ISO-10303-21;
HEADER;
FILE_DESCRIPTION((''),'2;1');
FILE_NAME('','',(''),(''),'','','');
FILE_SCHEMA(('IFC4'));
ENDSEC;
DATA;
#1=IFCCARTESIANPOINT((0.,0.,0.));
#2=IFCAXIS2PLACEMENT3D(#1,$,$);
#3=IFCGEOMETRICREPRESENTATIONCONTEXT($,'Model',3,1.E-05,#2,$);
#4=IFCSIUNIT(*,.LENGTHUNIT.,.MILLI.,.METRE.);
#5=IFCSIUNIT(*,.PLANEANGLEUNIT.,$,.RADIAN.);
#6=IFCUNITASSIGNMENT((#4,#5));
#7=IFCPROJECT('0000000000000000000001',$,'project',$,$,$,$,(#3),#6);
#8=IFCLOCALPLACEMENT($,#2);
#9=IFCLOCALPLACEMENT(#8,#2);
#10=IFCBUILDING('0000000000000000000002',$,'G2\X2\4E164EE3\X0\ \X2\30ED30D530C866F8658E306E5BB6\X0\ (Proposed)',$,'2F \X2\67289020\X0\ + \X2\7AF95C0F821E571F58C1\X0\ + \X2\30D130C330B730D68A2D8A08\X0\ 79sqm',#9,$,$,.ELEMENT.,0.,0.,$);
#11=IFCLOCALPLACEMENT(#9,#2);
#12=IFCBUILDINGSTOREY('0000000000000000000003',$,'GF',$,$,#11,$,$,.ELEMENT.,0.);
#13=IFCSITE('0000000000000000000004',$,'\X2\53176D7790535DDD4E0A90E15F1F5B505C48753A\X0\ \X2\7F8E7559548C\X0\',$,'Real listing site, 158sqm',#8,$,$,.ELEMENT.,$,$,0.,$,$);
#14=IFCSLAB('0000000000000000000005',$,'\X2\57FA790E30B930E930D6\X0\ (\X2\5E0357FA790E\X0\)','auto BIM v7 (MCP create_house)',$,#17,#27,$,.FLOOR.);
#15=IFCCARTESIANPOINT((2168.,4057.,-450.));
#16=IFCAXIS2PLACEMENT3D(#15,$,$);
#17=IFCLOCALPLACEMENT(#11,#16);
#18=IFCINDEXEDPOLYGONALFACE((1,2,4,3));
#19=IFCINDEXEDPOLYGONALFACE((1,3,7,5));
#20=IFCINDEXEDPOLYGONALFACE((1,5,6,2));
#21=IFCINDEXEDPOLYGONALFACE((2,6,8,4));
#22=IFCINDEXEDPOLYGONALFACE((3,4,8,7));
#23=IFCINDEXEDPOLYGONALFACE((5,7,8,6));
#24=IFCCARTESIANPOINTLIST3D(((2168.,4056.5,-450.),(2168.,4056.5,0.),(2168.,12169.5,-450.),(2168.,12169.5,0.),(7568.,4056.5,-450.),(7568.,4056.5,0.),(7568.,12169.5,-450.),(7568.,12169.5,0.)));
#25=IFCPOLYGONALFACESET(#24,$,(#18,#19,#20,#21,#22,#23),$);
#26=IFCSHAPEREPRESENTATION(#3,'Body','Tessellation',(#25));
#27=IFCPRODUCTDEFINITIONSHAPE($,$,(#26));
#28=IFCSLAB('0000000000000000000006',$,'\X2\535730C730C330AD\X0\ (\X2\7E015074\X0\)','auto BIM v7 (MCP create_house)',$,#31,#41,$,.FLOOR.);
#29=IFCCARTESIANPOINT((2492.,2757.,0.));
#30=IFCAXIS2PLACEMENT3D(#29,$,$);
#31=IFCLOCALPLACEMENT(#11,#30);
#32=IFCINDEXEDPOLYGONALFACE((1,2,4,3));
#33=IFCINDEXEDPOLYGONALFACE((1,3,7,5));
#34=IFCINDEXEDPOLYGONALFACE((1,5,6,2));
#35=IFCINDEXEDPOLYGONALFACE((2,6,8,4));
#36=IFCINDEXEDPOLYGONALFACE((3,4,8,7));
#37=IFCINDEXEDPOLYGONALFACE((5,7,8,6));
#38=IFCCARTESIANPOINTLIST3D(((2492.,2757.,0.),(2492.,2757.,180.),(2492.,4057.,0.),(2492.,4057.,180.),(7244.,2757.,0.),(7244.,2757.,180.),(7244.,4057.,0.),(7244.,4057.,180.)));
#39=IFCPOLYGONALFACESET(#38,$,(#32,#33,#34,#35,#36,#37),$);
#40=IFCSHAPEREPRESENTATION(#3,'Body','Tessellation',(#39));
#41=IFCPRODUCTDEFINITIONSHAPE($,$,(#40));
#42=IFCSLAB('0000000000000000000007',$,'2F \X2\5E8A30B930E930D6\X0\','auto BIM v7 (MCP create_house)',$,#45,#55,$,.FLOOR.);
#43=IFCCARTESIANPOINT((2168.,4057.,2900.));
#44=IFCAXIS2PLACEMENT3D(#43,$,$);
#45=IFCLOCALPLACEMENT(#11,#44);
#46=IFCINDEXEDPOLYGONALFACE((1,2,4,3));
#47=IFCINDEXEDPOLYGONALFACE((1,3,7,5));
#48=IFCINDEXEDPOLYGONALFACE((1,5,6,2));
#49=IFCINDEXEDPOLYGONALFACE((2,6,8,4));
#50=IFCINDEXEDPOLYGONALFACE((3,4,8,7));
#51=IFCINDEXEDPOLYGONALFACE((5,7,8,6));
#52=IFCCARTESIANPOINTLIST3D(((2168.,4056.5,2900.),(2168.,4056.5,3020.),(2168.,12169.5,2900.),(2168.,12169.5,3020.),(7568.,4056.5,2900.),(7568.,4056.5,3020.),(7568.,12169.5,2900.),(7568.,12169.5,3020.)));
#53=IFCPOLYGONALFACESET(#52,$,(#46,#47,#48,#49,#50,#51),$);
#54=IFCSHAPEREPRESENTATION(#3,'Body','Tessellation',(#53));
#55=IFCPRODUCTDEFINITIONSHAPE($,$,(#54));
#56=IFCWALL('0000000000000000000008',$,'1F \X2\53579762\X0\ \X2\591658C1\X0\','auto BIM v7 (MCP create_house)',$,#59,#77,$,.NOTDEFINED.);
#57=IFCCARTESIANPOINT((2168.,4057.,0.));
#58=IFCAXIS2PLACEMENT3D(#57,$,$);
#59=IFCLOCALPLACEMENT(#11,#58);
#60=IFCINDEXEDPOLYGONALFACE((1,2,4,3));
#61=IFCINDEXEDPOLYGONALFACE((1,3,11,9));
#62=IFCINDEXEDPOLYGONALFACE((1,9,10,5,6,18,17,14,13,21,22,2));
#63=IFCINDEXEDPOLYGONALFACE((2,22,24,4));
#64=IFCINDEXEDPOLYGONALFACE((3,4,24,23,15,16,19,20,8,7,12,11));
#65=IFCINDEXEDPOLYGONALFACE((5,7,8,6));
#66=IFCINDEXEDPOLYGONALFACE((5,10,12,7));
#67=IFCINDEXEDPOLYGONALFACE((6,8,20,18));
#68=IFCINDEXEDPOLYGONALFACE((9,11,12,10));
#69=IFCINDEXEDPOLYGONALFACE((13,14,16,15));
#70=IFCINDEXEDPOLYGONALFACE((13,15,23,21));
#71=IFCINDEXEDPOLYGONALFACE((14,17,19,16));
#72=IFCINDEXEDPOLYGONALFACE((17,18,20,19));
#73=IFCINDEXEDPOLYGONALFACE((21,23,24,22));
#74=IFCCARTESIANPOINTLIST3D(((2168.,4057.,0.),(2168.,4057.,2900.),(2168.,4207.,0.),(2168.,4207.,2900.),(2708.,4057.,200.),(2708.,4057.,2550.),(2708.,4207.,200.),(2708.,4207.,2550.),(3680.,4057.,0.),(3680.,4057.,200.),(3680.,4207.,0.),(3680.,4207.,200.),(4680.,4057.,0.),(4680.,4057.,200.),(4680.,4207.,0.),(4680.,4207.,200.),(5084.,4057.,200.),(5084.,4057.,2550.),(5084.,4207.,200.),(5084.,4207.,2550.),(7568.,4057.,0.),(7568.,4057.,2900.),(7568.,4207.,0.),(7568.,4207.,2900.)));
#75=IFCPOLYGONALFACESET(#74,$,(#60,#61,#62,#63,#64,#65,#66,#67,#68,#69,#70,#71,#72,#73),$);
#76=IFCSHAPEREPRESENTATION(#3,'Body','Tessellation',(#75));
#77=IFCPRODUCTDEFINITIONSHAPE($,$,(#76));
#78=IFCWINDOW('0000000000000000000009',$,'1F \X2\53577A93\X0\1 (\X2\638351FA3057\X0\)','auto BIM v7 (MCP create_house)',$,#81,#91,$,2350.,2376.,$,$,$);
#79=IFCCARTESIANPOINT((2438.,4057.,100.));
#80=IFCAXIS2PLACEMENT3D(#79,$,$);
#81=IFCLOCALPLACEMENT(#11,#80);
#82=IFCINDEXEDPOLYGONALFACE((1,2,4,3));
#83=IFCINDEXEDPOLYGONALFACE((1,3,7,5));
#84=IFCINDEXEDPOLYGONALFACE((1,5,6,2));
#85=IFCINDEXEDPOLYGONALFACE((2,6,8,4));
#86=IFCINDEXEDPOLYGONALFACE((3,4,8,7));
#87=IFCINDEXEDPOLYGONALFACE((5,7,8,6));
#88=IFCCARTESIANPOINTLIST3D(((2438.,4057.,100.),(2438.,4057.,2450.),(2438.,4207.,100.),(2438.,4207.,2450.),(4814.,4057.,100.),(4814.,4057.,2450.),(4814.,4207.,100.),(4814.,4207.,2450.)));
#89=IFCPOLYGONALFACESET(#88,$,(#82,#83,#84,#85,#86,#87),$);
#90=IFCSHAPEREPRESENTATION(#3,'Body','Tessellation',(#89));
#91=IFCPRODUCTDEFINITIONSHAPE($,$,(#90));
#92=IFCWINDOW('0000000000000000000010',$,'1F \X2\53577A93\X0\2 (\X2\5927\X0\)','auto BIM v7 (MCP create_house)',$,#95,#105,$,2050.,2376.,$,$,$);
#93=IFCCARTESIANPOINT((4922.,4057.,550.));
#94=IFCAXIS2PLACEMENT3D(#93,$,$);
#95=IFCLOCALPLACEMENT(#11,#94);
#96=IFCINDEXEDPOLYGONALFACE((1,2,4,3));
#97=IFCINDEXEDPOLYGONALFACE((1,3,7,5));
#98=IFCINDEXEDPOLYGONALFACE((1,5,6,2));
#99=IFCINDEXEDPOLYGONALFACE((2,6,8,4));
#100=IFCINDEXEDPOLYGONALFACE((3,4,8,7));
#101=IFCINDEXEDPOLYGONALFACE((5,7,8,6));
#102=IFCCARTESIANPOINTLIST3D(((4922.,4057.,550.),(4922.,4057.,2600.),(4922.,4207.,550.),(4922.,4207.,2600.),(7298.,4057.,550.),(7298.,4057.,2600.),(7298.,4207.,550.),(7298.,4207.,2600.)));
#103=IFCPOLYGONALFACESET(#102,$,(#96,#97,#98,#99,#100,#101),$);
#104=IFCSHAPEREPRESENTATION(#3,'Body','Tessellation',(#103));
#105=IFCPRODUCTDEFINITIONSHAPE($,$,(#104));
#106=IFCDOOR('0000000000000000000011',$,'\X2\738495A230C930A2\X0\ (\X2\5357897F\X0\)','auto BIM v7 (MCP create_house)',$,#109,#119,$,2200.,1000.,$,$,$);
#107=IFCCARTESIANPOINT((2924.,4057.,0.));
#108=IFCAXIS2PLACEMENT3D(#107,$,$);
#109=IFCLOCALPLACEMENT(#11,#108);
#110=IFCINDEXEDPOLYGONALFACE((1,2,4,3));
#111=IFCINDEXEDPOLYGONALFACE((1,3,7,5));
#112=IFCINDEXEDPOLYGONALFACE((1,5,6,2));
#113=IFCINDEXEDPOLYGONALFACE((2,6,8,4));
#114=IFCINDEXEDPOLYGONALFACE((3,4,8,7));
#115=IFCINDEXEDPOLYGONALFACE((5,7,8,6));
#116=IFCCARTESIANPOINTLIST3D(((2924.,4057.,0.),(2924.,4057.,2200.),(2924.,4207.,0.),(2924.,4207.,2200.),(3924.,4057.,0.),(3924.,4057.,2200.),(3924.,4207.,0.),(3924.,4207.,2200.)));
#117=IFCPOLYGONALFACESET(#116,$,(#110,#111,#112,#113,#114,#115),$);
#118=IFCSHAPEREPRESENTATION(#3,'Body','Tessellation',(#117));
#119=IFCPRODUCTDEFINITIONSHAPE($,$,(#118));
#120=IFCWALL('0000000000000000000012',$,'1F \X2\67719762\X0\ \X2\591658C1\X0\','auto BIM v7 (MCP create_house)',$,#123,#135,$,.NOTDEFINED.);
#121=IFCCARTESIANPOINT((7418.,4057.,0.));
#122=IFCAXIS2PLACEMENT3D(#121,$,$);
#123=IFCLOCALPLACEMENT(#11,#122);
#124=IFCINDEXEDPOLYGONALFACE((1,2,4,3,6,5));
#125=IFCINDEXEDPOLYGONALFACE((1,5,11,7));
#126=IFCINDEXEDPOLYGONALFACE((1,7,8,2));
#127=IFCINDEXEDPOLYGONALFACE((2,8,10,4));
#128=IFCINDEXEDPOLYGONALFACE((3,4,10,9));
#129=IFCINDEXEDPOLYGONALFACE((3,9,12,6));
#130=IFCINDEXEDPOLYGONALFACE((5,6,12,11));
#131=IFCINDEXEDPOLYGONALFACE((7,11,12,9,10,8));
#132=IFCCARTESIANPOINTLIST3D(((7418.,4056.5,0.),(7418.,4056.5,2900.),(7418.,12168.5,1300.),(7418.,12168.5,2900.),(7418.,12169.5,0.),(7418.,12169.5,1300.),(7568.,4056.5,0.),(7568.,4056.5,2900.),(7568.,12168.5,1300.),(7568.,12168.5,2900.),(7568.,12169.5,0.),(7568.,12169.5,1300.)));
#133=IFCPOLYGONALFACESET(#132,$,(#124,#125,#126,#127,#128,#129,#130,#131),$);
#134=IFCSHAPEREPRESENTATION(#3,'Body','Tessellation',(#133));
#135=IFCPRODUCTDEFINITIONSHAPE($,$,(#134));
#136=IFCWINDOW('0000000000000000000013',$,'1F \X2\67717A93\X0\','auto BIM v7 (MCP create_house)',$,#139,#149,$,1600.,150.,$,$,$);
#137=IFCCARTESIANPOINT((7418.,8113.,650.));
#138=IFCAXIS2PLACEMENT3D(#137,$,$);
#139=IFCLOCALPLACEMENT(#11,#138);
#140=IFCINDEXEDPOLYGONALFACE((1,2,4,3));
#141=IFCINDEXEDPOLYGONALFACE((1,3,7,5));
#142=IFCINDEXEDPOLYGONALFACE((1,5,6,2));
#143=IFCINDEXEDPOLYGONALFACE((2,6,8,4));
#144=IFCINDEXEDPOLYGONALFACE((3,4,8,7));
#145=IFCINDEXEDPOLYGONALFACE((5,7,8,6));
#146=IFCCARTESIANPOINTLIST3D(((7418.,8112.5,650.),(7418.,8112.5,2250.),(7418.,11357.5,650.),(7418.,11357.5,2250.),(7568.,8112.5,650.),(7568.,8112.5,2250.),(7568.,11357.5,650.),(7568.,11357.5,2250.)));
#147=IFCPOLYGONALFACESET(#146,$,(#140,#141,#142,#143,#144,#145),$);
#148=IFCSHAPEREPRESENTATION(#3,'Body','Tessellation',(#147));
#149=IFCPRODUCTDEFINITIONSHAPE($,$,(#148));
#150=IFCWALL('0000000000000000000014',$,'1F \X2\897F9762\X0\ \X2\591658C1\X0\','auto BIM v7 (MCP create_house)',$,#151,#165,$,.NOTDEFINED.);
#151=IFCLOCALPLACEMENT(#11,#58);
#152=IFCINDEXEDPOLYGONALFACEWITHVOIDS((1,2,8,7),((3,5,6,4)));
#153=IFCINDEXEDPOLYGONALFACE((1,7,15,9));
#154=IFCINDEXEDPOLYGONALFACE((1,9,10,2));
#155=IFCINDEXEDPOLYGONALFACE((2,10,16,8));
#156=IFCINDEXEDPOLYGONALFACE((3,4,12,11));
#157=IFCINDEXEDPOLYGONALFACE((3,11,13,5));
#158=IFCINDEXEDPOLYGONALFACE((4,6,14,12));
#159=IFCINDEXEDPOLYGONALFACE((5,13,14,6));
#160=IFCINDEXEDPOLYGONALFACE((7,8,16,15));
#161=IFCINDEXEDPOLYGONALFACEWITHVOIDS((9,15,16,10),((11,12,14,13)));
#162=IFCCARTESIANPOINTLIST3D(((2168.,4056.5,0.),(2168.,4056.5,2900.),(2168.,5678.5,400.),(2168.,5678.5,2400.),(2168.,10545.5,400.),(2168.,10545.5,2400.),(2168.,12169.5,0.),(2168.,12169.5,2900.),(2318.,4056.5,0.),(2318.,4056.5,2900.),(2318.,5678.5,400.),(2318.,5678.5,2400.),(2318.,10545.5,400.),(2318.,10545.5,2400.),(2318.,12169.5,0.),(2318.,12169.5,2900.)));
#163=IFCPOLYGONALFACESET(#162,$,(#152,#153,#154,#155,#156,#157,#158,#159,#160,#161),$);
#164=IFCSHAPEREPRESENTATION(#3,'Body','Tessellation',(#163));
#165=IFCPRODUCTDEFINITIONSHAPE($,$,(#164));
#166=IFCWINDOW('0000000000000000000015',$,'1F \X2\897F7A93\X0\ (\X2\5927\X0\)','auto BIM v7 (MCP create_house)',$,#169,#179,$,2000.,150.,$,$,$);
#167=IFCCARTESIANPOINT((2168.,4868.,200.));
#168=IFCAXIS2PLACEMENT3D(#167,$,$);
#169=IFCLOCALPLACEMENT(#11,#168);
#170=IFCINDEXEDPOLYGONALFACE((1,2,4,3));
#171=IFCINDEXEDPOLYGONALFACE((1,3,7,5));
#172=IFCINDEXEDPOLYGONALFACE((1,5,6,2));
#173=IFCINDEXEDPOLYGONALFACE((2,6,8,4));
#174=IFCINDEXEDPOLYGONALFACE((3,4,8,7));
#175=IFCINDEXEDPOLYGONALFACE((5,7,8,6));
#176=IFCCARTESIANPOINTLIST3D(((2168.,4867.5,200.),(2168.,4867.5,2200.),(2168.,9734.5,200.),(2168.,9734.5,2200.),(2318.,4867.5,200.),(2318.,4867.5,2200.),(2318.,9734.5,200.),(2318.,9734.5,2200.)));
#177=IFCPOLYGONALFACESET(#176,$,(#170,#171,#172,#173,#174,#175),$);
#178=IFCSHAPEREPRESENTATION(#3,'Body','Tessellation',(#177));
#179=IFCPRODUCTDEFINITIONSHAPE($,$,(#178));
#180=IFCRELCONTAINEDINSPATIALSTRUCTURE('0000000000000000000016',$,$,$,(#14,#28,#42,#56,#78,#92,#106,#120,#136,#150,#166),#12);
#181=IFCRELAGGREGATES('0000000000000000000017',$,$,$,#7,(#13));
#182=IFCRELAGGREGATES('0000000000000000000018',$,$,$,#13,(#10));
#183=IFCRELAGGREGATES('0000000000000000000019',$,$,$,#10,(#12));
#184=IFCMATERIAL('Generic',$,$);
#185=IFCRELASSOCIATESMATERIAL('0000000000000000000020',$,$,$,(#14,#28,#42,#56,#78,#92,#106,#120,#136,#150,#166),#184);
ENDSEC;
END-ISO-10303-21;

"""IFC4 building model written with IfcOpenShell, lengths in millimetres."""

from ifc_helpers import new_model, si_unit, frame, frame_2d, origin, place, context, project, spatial, rectangle, extrude, material, element, fill, save


model = new_model("IFC4")

# Units and contexts
model_context = context("Model", 3, precision=1e-05, world=origin())
ifc_project = project(units=[si_unit("LENGTHUNIT", "METRE", prefix="MILLI"), si_unit("PLANEANGLEUNIT", "RADIAN")], contexts=[model_context])

# Site, building, storey
site_placement = place(None, origin())
site = spatial("IfcSite", under=ifc_project, at=site_placement, Name="北海道川上郡弟子屈町 美留和", ObjectType="Real listing site, 158sqm", CompositionType="ELEMENT", RefElevation=0.0)
building_placement = place(site_placement, origin())
building = spatial("IfcBuilding", under=site, at=building_placement, Name="G2世代 ロフト書斎の家 (Proposed)", ObjectType="2F 木造 + 竹小舞土壁 + パッシブ設計 79sqm", CompositionType="ELEMENT", ElevationOfRefHeight=0.0, ElevationOfTerrain=0.0)
storey_placement = place(building_placement, origin())
storey = spatial("IfcBuildingStorey", under=building, at=storey_placement, Name="GF", CompositionType="ELEMENT", Elevation=0.0)

# Slabs
ifc_material = material(Name="Generic")
slab_1_placement = place(storey_placement, frame((2168.0, 4057.0, -450.0)))
element("IfcSlab", 1, at=slab_1_placement, inside=storey, material=ifc_material, Name="基礎スラブ (布基礎)", Description="auto BIM v7 (MCP create_house)", PredefinedType="FLOOR", context=model_context, shape_type="SweptSolid", body=[
    extrude(rectangle(XDim=5400.0, YDim=8113.0, at=frame_2d((2700.0, 4056.0))), frame((2168.0, 4057.0, -450.0)), (0.0, 0.0, 1.0), 450.0),
])
slab_2_placement = place(storey_placement, frame((2492.0, 2757.0, 0.0)))
element("IfcSlab", 2, at=slab_2_placement, inside=storey, material=ifc_material, Name="南デッキ (縁側)", Description="auto BIM v7 (MCP create_house)", PredefinedType="FLOOR", context=model_context, shape_type="SweptSolid", body=[
    extrude(rectangle(XDim=4752.0, YDim=1300.0, at=frame_2d((2376.0, 650.0))), frame((2492.0, 2757.0, 0.0)), (0.0, 0.0, 1.0), 180.0),
])
slab_3_placement = place(storey_placement, frame((2168.0, 4057.0, 2900.0)))
element("IfcSlab", 3, at=slab_3_placement, inside=storey, material=ifc_material, Name="2F 床スラブ", Description="auto BIM v7 (MCP create_house)", PredefinedType="FLOOR", context=model_context, shape_type="SweptSolid", body=[
    extrude(rectangle(XDim=5400.0, YDim=8113.0, at=frame_2d((2700.0, 4056.0))), frame((2168.0, 4057.0, 2900.0)), (0.0, 0.0, 1.0), 120.0),
])

# Wall, openings, windows, door
wall_1_placement = place(storey_placement, frame((2168.0, 4057.0, 0.0)))
wall_1 = element("IfcWall", 4, at=wall_1_placement, inside=storey, material=ifc_material, Name="1F 南面 外壁", Description="auto BIM v7 (MCP create_house)", PredefinedType="NOTDEFINED", context=model_context, shape_type="SweptSolid", body=[
    extrude(rectangle(XDim=5400.0, YDim=150.0, at=frame_2d((2700.0, 75.0))), frame((2168.0, 4057.0, 0.0)), (0.0, 0.0, 1.0), 2900.0),
])
opening_1_placement = place(storey_placement, frame((2438.0, 4057.0, 100.0)))
opening_1 = element("IfcOpeningElement", 5, at=opening_1_placement, cuts=wall_1, PredefinedType="NOTDEFINED", context=model_context, shape_type="SweptSolid", body=[
    extrude(rectangle(XDim=2376.0, YDim=150.0, at=frame_2d((1188.0, 75.0))), frame((2438.0, 4057.0, 100.0)), (0.0, 0.0, 1.0), 2350.0),
])
opening_2_placement = place(storey_placement, frame((4922.0, 4057.0, 550.0)))
opening_2 = element("IfcOpeningElement", 6, at=opening_2_placement, cuts=wall_1, PredefinedType="NOTDEFINED", context=model_context, shape_type="SweptSolid", body=[
    extrude(rectangle(XDim=2376.0, YDim=150.0, at=frame_2d((1188.0, 75.0))), frame((4922.0, 4057.0, 550.0)), (0.0, 0.0, 1.0), 2050.0),
])
opening_3_placement = place(storey_placement, frame((2924.0, 4057.0, 0.0)))
opening_3 = element("IfcOpeningElement", 7, at=opening_3_placement, cuts=wall_1, PredefinedType="NOTDEFINED", context=model_context, shape_type="SweptSolid", body=[
    extrude(rectangle(XDim=1000.0, YDim=150.0, at=frame_2d((500.0, 75.0))), frame((2924.0, 4057.0, 0.0)), (0.0, 0.0, 1.0), 2200.0),
])
window_1_placement = place(storey_placement, frame((2438.0, 4057.0, 100.0)))
window_1 = element("IfcWindow", 8, at=window_1_placement, inside=storey, material=ifc_material, Name="1F 南窓1 (掃出し)", Description="auto BIM v7 (MCP create_house)", OverallHeight=2350.0, OverallWidth=2376.0, context=model_context, shape_type="SweptSolid", body=[
    extrude(rectangle(XDim=2376.0, YDim=150.0, at=frame_2d((1188.0, 75.0))), frame((2438.0, 4057.0, 100.0)), (0.0, 0.0, 1.0), 2350.0),
])
fill(opening_1, window_1)
window_2_placement = place(storey_placement, frame((4922.0, 4057.0, 550.0)))
window_2 = element("IfcWindow", 9, at=window_2_placement, inside=storey, material=ifc_material, Name="1F 南窓2 (大)", Description="auto BIM v7 (MCP create_house)", OverallHeight=2050.0, OverallWidth=2376.0, context=model_context, shape_type="SweptSolid", body=[
    extrude(rectangle(XDim=2376.0, YDim=150.0, at=frame_2d((1188.0, 75.0))), frame((4922.0, 4057.0, 550.0)), (0.0, 0.0, 1.0), 2050.0),
])
fill(opening_2, window_2)
door_placement = place(storey_placement, frame((2924.0, 4057.0, 0.0)))
door = element("IfcDoor", 10, at=door_placement, inside=storey, material=ifc_material, Name="玄関ドア (南西)", Description="auto BIM v7 (MCP create_house)", OverallHeight=2200.0, OverallWidth=1000.0, context=model_context, shape_type="SweptSolid", body=[
    extrude(rectangle(XDim=1000.0, YDim=150.0, at=frame_2d((500.0, 75.0))), frame((2924.0, 4057.0, 0.0)), (0.0, 0.0, 1.0), 2200.0),
])
fill(opening_3, door)

# Walls, openings, windows
wall_2_placement = place(storey_placement, frame((7418.0, 4057.0, 0.0)))
wall_2 = element("IfcWall", 11, at=wall_2_placement, inside=storey, material=ifc_material, Name="1F 東面 外壁", Description="auto BIM v7 (MCP create_house)", PredefinedType="NOTDEFINED", context=model_context, shape_type="SweptSolid", body=[
    extrude(rectangle(XDim=150.0, YDim=8113.0, at=frame_2d((75.0, 4056.0))), frame((7418.0, 4057.0, 0.0)), (0.0, 0.0, 1.0), 2900.0),
])
opening_4_placement = place(storey_placement, frame((7418.0, 8113.0, 650.0)))
opening_4 = element("IfcOpeningElement", 12, at=opening_4_placement, cuts=wall_2, PredefinedType="NOTDEFINED", context=model_context, shape_type="SweptSolid", body=[
    extrude(rectangle(XDim=150.0, YDim=3245.0, at=frame_2d((75.0, 1622.0))), frame((7418.0, 8113.0, 650.0)), (0.0, 0.0, 1.0), 1600.0),
])
window_3_placement = place(storey_placement, frame((7418.0, 8113.0, 650.0)))
window_3 = element("IfcWindow", 13, at=window_3_placement, inside=storey, material=ifc_material, Name="1F 東窓", Description="auto BIM v7 (MCP create_house)", OverallHeight=1600.0, OverallWidth=150.0, context=model_context, shape_type="SweptSolid", body=[
    extrude(rectangle(XDim=150.0, YDim=3245.0, at=frame_2d((75.0, 1622.0))), frame((7418.0, 8113.0, 650.0)), (0.0, 0.0, 1.0), 1600.0),
])
fill(opening_4, window_3)
wall_3_placement = place(storey_placement, frame((2168.0, 4057.0, 0.0)))
wall_3 = element("IfcWall", 14, at=wall_3_placement, inside=storey, material=ifc_material, Name="1F 西面 外壁", Description="auto BIM v7 (MCP create_house)", PredefinedType="NOTDEFINED", context=model_context, shape_type="SweptSolid", body=[
    extrude(rectangle(XDim=150.0, YDim=8113.0, at=frame_2d((75.0, 4056.0))), frame((2168.0, 4057.0, 0.0)), (0.0, 0.0, 1.0), 2900.0),
])
opening_5_placement = place(storey_placement, frame((2168.0, 4868.0, 200.0)))
opening_5 = element("IfcOpeningElement", 15, at=opening_5_placement, cuts=wall_3, PredefinedType="NOTDEFINED", context=model_context, shape_type="SweptSolid", body=[
    extrude(rectangle(XDim=150.0, YDim=4867.0, at=frame_2d((75.0, 2433.0))), frame((2168.0, 4868.0, 200.0)), (0.0, 0.0, 1.0), 2000.0),
])
window_4_placement = place(storey_placement, frame((2168.0, 4868.0, 200.0)))
window_4 = element("IfcWindow", 16, at=window_4_placement, inside=storey, material=ifc_material, Name="1F 西窓 (大)", Description="auto BIM v7 (MCP create_house)", OverallHeight=2000.0, OverallWidth=150.0, context=model_context, shape_type="SweptSolid", body=[
    extrude(rectangle(XDim=150.0, YDim=4867.0, at=frame_2d((75.0, 2433.0))), frame((2168.0, 4868.0, 200.0)), (0.0, 0.0, 1.0), 2000.0),
])
fill(opening_5, window_4)

save(model, "model.ifc")
